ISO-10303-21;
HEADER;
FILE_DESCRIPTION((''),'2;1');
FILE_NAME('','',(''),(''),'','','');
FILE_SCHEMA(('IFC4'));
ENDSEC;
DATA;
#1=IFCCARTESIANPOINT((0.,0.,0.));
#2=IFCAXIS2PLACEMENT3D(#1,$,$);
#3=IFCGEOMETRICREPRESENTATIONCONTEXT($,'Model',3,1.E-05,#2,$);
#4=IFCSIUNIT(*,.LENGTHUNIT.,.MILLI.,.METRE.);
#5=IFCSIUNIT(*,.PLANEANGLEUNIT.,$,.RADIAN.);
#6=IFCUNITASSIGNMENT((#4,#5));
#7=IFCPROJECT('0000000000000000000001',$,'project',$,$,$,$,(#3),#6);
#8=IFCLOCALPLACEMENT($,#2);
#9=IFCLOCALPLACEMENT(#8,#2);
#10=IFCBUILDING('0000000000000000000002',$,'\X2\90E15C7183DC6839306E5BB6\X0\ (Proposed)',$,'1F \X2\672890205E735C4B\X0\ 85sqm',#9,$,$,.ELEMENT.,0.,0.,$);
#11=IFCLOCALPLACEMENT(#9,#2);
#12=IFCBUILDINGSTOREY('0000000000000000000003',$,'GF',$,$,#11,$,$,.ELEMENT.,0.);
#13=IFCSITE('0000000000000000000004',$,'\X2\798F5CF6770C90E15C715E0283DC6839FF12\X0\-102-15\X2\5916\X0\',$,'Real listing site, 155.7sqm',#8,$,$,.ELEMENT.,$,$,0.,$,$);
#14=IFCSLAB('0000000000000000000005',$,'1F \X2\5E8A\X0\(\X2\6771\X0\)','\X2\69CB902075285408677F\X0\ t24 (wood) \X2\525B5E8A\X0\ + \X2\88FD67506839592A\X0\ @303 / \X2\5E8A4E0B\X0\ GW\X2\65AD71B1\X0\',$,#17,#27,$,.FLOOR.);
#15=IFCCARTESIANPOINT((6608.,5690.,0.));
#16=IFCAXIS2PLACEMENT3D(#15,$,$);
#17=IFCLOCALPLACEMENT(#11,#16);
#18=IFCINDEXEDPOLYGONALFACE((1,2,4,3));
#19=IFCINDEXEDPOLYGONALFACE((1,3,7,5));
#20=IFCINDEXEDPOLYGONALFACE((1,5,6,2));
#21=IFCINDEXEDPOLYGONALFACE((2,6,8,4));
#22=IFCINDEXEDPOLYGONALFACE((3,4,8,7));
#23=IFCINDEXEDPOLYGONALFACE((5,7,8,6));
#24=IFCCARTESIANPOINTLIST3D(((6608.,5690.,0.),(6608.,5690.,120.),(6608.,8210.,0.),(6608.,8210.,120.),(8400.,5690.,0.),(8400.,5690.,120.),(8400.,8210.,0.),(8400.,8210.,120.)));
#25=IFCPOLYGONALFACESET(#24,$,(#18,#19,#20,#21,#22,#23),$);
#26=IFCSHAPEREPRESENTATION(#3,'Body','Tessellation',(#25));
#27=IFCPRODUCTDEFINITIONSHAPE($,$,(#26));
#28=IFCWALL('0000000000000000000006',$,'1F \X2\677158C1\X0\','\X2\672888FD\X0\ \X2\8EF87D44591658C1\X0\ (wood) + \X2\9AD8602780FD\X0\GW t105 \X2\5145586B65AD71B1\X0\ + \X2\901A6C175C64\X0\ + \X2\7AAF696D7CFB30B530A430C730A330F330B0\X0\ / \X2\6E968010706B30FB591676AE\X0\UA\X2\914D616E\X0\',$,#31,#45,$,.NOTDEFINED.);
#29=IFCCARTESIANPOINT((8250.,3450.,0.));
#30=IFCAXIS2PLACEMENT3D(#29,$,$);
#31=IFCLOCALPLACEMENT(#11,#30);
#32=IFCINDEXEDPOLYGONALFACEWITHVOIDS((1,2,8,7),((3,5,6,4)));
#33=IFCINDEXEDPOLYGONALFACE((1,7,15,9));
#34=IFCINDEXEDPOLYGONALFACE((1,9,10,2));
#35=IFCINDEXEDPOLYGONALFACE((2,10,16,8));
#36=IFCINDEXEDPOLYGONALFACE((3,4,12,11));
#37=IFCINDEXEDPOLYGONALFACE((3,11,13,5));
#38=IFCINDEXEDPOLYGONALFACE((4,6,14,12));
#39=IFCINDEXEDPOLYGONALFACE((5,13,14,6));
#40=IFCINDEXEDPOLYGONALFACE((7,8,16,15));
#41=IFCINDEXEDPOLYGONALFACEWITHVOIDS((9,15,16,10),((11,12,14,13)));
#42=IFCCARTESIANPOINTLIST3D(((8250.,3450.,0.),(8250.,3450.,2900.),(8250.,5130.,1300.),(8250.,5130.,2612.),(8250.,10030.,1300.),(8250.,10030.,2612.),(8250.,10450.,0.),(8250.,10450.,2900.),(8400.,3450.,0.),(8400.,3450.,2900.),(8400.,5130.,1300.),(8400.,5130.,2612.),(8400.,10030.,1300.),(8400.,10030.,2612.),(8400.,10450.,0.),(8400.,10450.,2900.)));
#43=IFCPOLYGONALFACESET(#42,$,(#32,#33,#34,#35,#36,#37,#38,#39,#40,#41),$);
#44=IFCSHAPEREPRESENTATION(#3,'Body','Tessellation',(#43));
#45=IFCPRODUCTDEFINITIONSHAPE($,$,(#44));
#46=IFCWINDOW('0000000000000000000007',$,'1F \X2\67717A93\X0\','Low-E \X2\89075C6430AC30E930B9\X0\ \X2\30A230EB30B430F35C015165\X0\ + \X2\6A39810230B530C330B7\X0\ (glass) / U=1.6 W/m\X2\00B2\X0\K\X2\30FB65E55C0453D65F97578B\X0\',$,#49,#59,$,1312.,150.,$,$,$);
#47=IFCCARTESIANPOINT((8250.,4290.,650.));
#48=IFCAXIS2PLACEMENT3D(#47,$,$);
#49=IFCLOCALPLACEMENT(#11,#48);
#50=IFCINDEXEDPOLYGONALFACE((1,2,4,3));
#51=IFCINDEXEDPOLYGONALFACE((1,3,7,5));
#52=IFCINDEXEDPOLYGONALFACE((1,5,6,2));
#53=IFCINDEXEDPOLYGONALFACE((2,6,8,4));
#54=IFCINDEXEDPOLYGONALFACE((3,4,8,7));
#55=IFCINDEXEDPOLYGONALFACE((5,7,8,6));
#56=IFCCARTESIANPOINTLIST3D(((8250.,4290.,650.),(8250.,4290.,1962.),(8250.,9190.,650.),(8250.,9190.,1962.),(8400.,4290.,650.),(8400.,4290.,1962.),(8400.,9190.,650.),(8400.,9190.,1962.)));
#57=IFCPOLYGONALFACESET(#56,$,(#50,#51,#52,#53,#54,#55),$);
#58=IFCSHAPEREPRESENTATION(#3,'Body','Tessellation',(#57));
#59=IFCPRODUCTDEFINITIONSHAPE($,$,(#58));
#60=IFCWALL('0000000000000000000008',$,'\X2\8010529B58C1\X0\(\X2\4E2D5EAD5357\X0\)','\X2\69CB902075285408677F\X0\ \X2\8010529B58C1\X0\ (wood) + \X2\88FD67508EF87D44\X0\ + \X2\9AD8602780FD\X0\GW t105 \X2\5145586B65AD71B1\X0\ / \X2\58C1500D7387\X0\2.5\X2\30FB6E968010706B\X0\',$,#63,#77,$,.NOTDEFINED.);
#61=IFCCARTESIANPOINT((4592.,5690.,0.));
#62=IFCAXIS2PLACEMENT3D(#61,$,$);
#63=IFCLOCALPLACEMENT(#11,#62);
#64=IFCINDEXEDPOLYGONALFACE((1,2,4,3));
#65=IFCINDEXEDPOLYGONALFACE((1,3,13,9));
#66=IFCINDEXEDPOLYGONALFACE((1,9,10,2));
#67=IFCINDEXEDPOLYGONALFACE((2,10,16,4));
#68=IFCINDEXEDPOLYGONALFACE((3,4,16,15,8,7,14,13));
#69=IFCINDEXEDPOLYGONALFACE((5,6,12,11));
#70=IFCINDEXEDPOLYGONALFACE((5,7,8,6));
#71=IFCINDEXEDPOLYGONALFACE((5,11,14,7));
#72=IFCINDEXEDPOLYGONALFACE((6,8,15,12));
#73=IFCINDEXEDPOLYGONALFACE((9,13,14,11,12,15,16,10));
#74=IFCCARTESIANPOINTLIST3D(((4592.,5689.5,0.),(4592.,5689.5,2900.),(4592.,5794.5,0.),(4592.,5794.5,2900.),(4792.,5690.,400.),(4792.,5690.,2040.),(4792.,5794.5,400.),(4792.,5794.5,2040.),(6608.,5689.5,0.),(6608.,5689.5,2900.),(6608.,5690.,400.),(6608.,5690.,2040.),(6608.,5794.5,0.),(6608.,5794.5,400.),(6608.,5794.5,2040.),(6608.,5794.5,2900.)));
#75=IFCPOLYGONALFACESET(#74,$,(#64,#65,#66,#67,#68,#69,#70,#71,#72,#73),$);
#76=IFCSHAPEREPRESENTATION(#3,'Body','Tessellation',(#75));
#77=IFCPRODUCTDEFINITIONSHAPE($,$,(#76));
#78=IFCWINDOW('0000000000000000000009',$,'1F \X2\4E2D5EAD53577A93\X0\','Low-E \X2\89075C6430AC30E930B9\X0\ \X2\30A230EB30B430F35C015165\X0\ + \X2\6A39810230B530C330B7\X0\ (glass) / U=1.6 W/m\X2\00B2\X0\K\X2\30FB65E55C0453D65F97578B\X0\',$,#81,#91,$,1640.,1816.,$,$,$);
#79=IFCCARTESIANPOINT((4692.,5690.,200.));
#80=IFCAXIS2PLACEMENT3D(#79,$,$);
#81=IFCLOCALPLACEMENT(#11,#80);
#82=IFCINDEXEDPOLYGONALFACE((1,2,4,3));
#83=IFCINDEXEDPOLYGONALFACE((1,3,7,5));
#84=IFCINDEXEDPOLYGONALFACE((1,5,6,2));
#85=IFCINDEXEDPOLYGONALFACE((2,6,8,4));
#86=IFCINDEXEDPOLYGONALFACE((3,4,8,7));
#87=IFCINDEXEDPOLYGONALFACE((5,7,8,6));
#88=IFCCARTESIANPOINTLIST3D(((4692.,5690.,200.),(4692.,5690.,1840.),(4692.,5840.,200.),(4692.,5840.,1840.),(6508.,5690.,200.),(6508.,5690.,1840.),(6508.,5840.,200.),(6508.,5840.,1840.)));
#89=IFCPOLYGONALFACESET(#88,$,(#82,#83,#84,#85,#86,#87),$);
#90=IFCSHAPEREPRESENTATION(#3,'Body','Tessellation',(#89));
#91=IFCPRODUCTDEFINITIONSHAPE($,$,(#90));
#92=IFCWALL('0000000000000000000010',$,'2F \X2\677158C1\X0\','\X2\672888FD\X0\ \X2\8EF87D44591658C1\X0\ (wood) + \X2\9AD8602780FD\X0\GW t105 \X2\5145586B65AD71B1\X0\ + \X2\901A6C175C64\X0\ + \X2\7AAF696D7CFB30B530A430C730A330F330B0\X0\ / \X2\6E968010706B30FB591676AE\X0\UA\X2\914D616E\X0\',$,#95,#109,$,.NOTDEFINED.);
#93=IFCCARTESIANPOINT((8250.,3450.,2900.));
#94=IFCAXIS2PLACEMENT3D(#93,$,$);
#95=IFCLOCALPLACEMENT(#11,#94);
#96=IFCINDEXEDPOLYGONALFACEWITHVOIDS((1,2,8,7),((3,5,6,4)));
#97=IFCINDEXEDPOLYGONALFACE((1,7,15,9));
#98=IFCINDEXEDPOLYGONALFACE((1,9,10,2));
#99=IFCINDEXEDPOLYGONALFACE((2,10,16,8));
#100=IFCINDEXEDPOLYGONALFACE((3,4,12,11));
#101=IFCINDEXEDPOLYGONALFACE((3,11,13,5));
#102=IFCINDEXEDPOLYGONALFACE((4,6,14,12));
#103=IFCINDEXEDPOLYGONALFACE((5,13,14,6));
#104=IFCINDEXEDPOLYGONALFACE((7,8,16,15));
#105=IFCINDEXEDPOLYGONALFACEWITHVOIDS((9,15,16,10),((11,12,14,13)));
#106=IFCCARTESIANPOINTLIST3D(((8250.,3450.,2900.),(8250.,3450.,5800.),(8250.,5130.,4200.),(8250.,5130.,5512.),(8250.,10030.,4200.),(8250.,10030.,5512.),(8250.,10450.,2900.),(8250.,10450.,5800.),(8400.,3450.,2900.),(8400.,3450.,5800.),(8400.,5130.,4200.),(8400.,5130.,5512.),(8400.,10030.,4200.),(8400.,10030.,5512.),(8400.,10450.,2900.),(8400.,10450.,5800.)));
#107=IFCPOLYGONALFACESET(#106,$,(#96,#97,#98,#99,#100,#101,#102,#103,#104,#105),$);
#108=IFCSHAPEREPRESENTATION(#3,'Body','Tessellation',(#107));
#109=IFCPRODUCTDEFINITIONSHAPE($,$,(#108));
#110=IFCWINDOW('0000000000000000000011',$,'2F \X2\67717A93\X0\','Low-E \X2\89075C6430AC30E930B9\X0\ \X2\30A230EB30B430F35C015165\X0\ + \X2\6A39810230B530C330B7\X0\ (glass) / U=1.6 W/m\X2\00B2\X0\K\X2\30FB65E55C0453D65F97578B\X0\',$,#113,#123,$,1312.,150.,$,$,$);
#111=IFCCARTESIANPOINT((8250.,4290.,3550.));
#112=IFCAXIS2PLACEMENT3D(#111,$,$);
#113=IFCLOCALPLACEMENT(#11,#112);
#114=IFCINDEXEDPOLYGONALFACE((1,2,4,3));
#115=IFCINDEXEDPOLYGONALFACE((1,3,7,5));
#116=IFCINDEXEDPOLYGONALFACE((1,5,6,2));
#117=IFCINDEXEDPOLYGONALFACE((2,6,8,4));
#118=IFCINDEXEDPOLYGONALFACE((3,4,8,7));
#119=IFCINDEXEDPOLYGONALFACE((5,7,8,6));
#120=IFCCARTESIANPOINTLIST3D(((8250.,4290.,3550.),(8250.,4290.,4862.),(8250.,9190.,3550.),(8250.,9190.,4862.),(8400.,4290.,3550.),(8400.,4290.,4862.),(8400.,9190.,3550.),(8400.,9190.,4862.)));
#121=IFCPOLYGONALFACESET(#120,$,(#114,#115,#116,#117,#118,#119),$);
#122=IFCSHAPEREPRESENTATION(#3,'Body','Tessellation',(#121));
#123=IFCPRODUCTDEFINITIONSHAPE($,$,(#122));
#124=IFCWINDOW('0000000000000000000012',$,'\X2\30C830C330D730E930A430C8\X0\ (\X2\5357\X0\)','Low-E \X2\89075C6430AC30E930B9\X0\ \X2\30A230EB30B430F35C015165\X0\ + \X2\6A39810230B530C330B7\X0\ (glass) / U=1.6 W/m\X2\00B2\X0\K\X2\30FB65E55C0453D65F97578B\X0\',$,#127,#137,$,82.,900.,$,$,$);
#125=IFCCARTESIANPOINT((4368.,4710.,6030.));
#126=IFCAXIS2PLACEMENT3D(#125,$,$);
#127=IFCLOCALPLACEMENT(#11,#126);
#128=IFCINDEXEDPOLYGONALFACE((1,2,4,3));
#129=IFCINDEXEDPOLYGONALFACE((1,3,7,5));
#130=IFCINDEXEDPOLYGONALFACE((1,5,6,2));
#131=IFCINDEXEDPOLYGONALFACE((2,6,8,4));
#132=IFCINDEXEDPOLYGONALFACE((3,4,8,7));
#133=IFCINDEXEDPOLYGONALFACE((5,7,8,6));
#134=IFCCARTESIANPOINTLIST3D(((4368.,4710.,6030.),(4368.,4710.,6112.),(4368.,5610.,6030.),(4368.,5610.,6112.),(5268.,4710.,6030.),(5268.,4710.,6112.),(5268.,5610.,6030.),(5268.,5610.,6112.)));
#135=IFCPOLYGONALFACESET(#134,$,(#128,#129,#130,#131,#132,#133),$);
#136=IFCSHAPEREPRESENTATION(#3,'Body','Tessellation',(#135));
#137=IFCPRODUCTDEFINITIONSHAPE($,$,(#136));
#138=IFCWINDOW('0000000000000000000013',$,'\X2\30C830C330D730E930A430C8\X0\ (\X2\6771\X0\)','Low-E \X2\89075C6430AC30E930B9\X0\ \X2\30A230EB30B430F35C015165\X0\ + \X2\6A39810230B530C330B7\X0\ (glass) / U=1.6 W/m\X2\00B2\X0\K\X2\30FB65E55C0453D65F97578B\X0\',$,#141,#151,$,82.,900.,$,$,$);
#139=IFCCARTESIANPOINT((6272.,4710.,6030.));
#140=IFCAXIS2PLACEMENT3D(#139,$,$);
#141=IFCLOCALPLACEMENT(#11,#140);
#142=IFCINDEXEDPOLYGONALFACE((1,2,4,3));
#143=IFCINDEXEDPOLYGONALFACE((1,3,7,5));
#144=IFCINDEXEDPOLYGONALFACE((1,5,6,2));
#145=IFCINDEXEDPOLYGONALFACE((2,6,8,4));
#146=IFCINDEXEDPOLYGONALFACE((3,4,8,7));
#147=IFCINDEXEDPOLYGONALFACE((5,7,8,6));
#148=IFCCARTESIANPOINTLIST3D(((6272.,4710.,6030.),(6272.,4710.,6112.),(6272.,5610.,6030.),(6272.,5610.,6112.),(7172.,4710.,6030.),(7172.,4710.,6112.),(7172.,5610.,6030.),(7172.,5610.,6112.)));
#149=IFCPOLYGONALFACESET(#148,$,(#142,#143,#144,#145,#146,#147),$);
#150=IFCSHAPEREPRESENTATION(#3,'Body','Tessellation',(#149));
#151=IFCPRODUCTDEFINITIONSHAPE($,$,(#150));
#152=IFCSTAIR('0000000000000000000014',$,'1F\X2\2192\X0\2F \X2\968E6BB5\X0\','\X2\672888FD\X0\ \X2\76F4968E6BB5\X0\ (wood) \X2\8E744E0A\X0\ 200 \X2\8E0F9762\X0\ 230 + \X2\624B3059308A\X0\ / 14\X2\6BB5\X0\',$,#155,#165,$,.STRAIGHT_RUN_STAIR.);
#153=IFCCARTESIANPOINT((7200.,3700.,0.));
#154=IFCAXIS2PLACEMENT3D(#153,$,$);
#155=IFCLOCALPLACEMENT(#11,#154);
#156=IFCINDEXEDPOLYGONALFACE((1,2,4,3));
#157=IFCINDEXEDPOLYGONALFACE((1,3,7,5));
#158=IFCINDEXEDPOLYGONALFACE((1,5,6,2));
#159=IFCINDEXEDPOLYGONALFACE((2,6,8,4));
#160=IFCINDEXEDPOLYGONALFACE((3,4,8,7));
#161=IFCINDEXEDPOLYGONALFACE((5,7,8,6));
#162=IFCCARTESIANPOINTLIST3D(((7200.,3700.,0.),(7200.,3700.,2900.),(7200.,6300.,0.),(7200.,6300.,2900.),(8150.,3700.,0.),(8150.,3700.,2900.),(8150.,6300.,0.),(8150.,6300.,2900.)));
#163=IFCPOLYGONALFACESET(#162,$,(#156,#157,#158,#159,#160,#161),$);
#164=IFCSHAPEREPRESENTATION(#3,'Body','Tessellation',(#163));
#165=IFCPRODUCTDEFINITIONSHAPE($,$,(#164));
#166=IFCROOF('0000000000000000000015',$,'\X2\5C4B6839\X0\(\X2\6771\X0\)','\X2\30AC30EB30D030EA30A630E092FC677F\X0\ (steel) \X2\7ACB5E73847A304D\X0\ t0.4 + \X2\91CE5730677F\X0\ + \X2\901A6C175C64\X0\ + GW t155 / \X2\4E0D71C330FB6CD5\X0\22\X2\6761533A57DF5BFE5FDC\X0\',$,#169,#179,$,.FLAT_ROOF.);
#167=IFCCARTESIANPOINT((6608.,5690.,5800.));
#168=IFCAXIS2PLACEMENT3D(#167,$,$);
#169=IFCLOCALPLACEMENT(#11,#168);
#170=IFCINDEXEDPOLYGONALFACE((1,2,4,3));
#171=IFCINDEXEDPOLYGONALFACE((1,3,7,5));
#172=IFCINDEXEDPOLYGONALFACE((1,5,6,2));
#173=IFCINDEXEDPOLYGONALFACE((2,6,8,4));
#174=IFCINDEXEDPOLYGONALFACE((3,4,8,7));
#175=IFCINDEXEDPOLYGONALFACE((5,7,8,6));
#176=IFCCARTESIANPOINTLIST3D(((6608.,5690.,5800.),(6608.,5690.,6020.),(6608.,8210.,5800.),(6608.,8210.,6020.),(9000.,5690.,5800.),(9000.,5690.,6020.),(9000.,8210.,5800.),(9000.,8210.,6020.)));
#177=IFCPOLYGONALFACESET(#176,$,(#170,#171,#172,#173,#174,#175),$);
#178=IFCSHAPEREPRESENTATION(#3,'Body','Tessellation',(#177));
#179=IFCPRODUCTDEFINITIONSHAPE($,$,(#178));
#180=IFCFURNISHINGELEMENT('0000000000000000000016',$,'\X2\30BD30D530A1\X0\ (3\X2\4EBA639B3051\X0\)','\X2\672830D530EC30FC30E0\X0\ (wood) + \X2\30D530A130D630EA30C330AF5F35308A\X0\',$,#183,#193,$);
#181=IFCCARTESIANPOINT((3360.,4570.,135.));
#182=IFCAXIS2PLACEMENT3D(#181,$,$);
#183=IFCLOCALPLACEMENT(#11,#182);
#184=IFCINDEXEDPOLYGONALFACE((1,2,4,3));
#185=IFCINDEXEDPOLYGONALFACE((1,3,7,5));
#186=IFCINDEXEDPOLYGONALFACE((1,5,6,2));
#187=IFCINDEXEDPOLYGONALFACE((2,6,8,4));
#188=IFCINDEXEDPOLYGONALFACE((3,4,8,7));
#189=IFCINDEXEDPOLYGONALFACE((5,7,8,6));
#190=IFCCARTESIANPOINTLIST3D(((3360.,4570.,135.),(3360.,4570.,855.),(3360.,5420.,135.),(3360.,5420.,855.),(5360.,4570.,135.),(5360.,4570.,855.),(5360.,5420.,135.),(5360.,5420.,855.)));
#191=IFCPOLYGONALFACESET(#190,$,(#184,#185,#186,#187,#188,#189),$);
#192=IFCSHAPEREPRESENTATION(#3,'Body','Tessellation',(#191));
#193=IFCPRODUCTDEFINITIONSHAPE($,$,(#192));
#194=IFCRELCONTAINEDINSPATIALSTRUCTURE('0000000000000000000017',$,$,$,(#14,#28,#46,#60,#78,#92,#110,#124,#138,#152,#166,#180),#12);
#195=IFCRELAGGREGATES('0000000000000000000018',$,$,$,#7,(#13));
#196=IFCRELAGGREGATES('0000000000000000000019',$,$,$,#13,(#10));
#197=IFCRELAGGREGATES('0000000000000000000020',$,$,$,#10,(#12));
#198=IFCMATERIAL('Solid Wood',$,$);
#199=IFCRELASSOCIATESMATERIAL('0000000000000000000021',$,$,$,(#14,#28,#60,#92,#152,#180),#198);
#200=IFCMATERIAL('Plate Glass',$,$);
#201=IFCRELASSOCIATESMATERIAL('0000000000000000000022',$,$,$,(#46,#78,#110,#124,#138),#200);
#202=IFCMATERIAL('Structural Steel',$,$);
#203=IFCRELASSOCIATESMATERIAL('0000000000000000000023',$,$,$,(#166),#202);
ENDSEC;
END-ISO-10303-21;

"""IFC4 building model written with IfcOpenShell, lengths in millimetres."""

from ifc_helpers import new_model, si_unit, frame, frame_2d, origin, place, context, project, spatial, rectangle, extrude, material, element, fill, save


model = new_model("IFC4")

# Units and contexts
model_context = context("Model", 3, precision=1e-05, world=origin())
ifc_project = project(units=[si_unit("LENGTHUNIT", "METRE", prefix="MILLI"), si_unit("PLANEANGLEUNIT", "RADIAN")], contexts=[model_context])

# Site, building, storey
site_placement = place(None, origin())
site = spatial("IfcSite", under=ifc_project, at=site_placement, Name="福島県郡山市菜根２-102-15外", ObjectType="Real listing site, 155.7sqm", CompositionType="ELEMENT", RefElevation=0.0)
building_placement = place(site_placement, origin())
building = spatial("IfcBuilding", under=site, at=building_placement, Name="郡山菜根の家 (Proposed)", ObjectType="1F 木造平屋 85sqm", CompositionType="ELEMENT", ElevationOfRefHeight=0.0, ElevationOfTerrain=0.0)
storey_placement = place(building_placement, origin())
storey = spatial("IfcBuildingStorey", under=building, at=storey_placement, Name="GF", CompositionType="ELEMENT", Elevation=0.0)

# Slab
ifc_material_1 = material(Name="Solid Wood")
slab_placement = place(storey_placement, frame((6608.0, 5690.0, 0.0)))
element("IfcSlab", 1, at=slab_placement, inside=storey, material=ifc_material_1, Name="1F 床(東)", Description="構造用合板 t24 (wood) 剛床 + 製材根太 @303 / 床下 GW断熱", PredefinedType="FLOOR", context=model_context, shape_type="SweptSolid", body=[
    extrude(rectangle(XDim=1792.0, YDim=2520.0, at=frame_2d((896.0, 1260.0))), frame((6608.0, 5690.0, 0.0)), (0.0, 0.0, 1.0), 120.0),
])

# Walls, openings, windows
wall_1_placement = place(storey_placement, frame((8250.0, 3450.0, 0.0)))
wall_1 = element("IfcWall", 2, at=wall_1_placement, inside=storey, material=ifc_material_1, Name="1F 東壁", Description="木製 軸組外壁 (wood) + 高性能GW t105 充填断熱 + 通気層 + 窯業系サイディング / 準耐火・外皮UA配慮", PredefinedType="NOTDEFINED", context=model_context, shape_type="SweptSolid", body=[
    extrude(rectangle(XDim=150.0, YDim=7000.0, at=frame_2d((75.0, 3500.0))), frame((8250.0, 3450.0, 0.0)), (0.0, 0.0, 1.0), 2900.0),
])
opening_1_placement = place(storey_placement, frame((8250.0, 4290.0, 650.0)))
opening_1 = element("IfcOpeningElement", 3, at=opening_1_placement, cuts=wall_1, PredefinedType="NOTDEFINED", context=model_context, shape_type="SweptSolid", body=[
    extrude(rectangle(XDim=150.0, YDim=4900.0, at=frame_2d((75.0, 2450.0))), frame((8250.0, 4290.0, 650.0)), (0.0, 0.0, 1.0), 1312.0),
])
ifc_material_2 = material(Name="Plate Glass")
window_1_placement = place(storey_placement, frame((8250.0, 4290.0, 650.0)))
window_1 = element("IfcWindow", 4, at=window_1_placement, inside=storey, material=ifc_material_2, Name="1F 東窓", Description="Low-E 複層ガラス アルゴン封入 + 樹脂サッシ (glass) / U=1.6 W/m²K・日射取得型", OverallHeight=1312.0, OverallWidth=150.0, context=model_context, shape_type="SweptSolid", body=[
    extrude(rectangle(XDim=150.0, YDim=4900.0, at=frame_2d((75.0, 2450.0))), frame((8250.0, 4290.0, 650.0)), (0.0, 0.0, 1.0), 1312.0),
])
fill(opening_1, window_1)
wall_2_placement = place(storey_placement, frame((4592.0, 5690.0, 0.0)))
wall_2 = element("IfcWall", 5, at=wall_2_placement, inside=storey, material=ifc_material_1, Name="耐力壁(中庭南)", Description="構造用合板 耐力壁 (wood) + 製材軸組 + 高性能GW t105 充填断熱 / 壁倍率2.5・準耐火", PredefinedType="NOTDEFINED", context=model_context, shape_type="SweptSolid", body=[
    extrude(rectangle(XDim=2016.0, YDim=105.0, at=frame_2d((1008.0, 52.0))), frame((4592.0, 5690.0, 0.0)), (0.0, 0.0, 1.0), 2900.0),
])
opening_2_placement = place(storey_placement, frame((4692.0, 5690.0, 200.0)))
opening_2 = element("IfcOpeningElement", 6, at=opening_2_placement, cuts=wall_2, PredefinedType="NOTDEFINED", context=model_context, shape_type="SweptSolid", body=[
    extrude(rectangle(XDim=1816.0, YDim=150.0, at=frame_2d((908.0, 75.0))), frame((4692.0, 5690.0, 200.0)), (0.0, 0.0, 1.0), 1640.0),
])
window_2_placement = place(storey_placement, frame((4692.0, 5690.0, 200.0)))
window_2 = element("IfcWindow", 7, at=window_2_placement, inside=storey, material=ifc_material_2, Name="1F 中庭南窓", Description="Low-E 複層ガラス アルゴン封入 + 樹脂サッシ (glass) / U=1.6 W/m²K・日射取得型", OverallHeight=1640.0, OverallWidth=1816.0, context=model_context, shape_type="SweptSolid", body=[
    extrude(rectangle(XDim=1816.0, YDim=150.0, at=frame_2d((908.0, 75.0))), frame((4692.0, 5690.0, 200.0)), (0.0, 0.0, 1.0), 1640.0),
])
fill(opening_2, window_2)

# Wall, opening, window
wall_3_placement = place(storey_placement, frame((8250.0, 3450.0, 2900.0)))
wall_3 = element("IfcWall", 8, at=wall_3_placement, inside=storey, material=ifc_material_1, Name="2F 東壁", Description="木製 軸組外壁 (wood) + 高性能GW t105 充填断熱 + 通気層 + 窯業系サイディング / 準耐火・外皮UA配慮", PredefinedType="NOTDEFINED", context=model_context, shape_type="SweptSolid", body=[
    extrude(rectangle(XDim=150.0, YDim=7000.0, at=frame_2d((75.0, 3500.0))), frame((8250.0, 3450.0, 2900.0)), (0.0, 0.0, 1.0), 2900.0),
])
opening_3_placement = place(storey_placement, frame((8250.0, 4290.0, 3550.0)))
opening_3 = element("IfcOpeningElement", 9, at=opening_3_placement, cuts=wall_3, PredefinedType="NOTDEFINED", context=model_context, shape_type="SweptSolid", body=[
    extrude(rectangle(XDim=150.0, YDim=4900.0, at=frame_2d((75.0, 2450.0))), frame((8250.0, 4290.0, 3550.0)), (0.0, 0.0, 1.0), 1312.0),
])
window_3_placement = place(storey_placement, frame((8250.0, 4290.0, 3550.0)))
window_3 = element("IfcWindow", 10, at=window_3_placement, inside=storey, material=ifc_material_2, Name="2F 東窓", Description="Low-E 複層ガラス アルゴン封入 + 樹脂サッシ (glass) / U=1.6 W/m²K・日射取得型", OverallHeight=1312.0, OverallWidth=150.0, context=model_context, shape_type="SweptSolid", body=[
    extrude(rectangle(XDim=150.0, YDim=4900.0, at=frame_2d((75.0, 2450.0))), frame((8250.0, 4290.0, 3550.0)), (0.0, 0.0, 1.0), 1312.0),
])
fill(opening_3, window_3)

# Windows
window_4_placement = place(storey_placement, frame((4368.0, 4710.0, 6030.0)))
element("IfcWindow", 11, at=window_4_placement, inside=storey, material=ifc_material_2, Name="トップライト (南)", Description="Low-E 複層ガラス アルゴン封入 + 樹脂サッシ (glass) / U=1.6 W/m²K・日射取得型", OverallHeight=82.0, OverallWidth=900.0, context=model_context, shape_type="SweptSolid", body=[
    extrude(rectangle(XDim=900.0, YDim=900.0, at=frame_2d((450.0, 450.0))), frame((4368.0, 4710.0, 6030.0)), (0.0, 0.0, 1.0), 82.0),
])
window_5_placement = place(storey_placement, frame((6272.0, 4710.0, 6030.0)))
element("IfcWindow", 12, at=window_5_placement, inside=storey, material=ifc_material_2, Name="トップライト (東)", Description="Low-E 複層ガラス アルゴン封入 + 樹脂サッシ (glass) / U=1.6 W/m²K・日射取得型", OverallHeight=82.0, OverallWidth=900.0, context=model_context, shape_type="SweptSolid", body=[
    extrude(rectangle(XDim=900.0, YDim=900.0, at=frame_2d((450.0, 450.0))), frame((6272.0, 4710.0, 6030.0)), (0.0, 0.0, 1.0), 82.0),
])

# Stair
stair_placement = place(storey_placement, frame((7200.0, 3700.0, 0.0)))
element("IfcStair", 13, at=stair_placement, inside=storey, material=ifc_material_1, Name="1F→2F 階段", Description="木製 直階段 (wood) 蹴上 200 踏面 230 + 手すり / 14段", PredefinedType="STRAIGHT_RUN_STAIR", context=model_context, shape_type="SweptSolid", body=[
    extrude(rectangle(XDim=950.0, YDim=2600.0, at=frame_2d((475.0, 1300.0))), frame((7200.0, 3700.0, 0.0)), (0.0, 0.0, 1.0), 2900.0),
])

# Roof
ifc_material_3 = material(Name="Structural Steel")
roof_placement = place(storey_placement, frame((6608.0, 5690.0, 5800.0)))
element("IfcRoof", 14, at=roof_placement, inside=storey, material=ifc_material_3, Name="屋根(東)", Description="ガルバリウム鋼板 (steel) 立平葺き t0.4 + 野地板 + 通気層 + GW t155 / 不燃・法22条区域対応", PredefinedType="FLAT_ROOF", context=model_context, shape_type="SweptSolid", body=[
    extrude(rectangle(XDim=2392.0, YDim=2520.0, at=frame_2d((1196.0, 1260.0))), frame((6608.0, 5690.0, 5800.0)), (0.0, 0.0, 1.0), 220.0),
])

# Furnishing element
furnishing_1_placement = place(storey_placement, frame((3360.0, 4570.0, 135.0)))
element("IfcFurnishingElement", 15, at=furnishing_1_placement, inside=storey, material=ifc_material_1, Name="ソファ (3人掛け)", Description="木フレーム (wood) + ファブリック張り", context=model_context, shape_type="SweptSolid", body=[
    extrude(rectangle(XDim=2000.0, YDim=850.0, at=frame_2d((1000.0, 425.0))), frame((3360.0, 4570.0, 135.0)), (0.0, 0.0, 1.0), 720.0),
])

save(model, "model.ifc")
